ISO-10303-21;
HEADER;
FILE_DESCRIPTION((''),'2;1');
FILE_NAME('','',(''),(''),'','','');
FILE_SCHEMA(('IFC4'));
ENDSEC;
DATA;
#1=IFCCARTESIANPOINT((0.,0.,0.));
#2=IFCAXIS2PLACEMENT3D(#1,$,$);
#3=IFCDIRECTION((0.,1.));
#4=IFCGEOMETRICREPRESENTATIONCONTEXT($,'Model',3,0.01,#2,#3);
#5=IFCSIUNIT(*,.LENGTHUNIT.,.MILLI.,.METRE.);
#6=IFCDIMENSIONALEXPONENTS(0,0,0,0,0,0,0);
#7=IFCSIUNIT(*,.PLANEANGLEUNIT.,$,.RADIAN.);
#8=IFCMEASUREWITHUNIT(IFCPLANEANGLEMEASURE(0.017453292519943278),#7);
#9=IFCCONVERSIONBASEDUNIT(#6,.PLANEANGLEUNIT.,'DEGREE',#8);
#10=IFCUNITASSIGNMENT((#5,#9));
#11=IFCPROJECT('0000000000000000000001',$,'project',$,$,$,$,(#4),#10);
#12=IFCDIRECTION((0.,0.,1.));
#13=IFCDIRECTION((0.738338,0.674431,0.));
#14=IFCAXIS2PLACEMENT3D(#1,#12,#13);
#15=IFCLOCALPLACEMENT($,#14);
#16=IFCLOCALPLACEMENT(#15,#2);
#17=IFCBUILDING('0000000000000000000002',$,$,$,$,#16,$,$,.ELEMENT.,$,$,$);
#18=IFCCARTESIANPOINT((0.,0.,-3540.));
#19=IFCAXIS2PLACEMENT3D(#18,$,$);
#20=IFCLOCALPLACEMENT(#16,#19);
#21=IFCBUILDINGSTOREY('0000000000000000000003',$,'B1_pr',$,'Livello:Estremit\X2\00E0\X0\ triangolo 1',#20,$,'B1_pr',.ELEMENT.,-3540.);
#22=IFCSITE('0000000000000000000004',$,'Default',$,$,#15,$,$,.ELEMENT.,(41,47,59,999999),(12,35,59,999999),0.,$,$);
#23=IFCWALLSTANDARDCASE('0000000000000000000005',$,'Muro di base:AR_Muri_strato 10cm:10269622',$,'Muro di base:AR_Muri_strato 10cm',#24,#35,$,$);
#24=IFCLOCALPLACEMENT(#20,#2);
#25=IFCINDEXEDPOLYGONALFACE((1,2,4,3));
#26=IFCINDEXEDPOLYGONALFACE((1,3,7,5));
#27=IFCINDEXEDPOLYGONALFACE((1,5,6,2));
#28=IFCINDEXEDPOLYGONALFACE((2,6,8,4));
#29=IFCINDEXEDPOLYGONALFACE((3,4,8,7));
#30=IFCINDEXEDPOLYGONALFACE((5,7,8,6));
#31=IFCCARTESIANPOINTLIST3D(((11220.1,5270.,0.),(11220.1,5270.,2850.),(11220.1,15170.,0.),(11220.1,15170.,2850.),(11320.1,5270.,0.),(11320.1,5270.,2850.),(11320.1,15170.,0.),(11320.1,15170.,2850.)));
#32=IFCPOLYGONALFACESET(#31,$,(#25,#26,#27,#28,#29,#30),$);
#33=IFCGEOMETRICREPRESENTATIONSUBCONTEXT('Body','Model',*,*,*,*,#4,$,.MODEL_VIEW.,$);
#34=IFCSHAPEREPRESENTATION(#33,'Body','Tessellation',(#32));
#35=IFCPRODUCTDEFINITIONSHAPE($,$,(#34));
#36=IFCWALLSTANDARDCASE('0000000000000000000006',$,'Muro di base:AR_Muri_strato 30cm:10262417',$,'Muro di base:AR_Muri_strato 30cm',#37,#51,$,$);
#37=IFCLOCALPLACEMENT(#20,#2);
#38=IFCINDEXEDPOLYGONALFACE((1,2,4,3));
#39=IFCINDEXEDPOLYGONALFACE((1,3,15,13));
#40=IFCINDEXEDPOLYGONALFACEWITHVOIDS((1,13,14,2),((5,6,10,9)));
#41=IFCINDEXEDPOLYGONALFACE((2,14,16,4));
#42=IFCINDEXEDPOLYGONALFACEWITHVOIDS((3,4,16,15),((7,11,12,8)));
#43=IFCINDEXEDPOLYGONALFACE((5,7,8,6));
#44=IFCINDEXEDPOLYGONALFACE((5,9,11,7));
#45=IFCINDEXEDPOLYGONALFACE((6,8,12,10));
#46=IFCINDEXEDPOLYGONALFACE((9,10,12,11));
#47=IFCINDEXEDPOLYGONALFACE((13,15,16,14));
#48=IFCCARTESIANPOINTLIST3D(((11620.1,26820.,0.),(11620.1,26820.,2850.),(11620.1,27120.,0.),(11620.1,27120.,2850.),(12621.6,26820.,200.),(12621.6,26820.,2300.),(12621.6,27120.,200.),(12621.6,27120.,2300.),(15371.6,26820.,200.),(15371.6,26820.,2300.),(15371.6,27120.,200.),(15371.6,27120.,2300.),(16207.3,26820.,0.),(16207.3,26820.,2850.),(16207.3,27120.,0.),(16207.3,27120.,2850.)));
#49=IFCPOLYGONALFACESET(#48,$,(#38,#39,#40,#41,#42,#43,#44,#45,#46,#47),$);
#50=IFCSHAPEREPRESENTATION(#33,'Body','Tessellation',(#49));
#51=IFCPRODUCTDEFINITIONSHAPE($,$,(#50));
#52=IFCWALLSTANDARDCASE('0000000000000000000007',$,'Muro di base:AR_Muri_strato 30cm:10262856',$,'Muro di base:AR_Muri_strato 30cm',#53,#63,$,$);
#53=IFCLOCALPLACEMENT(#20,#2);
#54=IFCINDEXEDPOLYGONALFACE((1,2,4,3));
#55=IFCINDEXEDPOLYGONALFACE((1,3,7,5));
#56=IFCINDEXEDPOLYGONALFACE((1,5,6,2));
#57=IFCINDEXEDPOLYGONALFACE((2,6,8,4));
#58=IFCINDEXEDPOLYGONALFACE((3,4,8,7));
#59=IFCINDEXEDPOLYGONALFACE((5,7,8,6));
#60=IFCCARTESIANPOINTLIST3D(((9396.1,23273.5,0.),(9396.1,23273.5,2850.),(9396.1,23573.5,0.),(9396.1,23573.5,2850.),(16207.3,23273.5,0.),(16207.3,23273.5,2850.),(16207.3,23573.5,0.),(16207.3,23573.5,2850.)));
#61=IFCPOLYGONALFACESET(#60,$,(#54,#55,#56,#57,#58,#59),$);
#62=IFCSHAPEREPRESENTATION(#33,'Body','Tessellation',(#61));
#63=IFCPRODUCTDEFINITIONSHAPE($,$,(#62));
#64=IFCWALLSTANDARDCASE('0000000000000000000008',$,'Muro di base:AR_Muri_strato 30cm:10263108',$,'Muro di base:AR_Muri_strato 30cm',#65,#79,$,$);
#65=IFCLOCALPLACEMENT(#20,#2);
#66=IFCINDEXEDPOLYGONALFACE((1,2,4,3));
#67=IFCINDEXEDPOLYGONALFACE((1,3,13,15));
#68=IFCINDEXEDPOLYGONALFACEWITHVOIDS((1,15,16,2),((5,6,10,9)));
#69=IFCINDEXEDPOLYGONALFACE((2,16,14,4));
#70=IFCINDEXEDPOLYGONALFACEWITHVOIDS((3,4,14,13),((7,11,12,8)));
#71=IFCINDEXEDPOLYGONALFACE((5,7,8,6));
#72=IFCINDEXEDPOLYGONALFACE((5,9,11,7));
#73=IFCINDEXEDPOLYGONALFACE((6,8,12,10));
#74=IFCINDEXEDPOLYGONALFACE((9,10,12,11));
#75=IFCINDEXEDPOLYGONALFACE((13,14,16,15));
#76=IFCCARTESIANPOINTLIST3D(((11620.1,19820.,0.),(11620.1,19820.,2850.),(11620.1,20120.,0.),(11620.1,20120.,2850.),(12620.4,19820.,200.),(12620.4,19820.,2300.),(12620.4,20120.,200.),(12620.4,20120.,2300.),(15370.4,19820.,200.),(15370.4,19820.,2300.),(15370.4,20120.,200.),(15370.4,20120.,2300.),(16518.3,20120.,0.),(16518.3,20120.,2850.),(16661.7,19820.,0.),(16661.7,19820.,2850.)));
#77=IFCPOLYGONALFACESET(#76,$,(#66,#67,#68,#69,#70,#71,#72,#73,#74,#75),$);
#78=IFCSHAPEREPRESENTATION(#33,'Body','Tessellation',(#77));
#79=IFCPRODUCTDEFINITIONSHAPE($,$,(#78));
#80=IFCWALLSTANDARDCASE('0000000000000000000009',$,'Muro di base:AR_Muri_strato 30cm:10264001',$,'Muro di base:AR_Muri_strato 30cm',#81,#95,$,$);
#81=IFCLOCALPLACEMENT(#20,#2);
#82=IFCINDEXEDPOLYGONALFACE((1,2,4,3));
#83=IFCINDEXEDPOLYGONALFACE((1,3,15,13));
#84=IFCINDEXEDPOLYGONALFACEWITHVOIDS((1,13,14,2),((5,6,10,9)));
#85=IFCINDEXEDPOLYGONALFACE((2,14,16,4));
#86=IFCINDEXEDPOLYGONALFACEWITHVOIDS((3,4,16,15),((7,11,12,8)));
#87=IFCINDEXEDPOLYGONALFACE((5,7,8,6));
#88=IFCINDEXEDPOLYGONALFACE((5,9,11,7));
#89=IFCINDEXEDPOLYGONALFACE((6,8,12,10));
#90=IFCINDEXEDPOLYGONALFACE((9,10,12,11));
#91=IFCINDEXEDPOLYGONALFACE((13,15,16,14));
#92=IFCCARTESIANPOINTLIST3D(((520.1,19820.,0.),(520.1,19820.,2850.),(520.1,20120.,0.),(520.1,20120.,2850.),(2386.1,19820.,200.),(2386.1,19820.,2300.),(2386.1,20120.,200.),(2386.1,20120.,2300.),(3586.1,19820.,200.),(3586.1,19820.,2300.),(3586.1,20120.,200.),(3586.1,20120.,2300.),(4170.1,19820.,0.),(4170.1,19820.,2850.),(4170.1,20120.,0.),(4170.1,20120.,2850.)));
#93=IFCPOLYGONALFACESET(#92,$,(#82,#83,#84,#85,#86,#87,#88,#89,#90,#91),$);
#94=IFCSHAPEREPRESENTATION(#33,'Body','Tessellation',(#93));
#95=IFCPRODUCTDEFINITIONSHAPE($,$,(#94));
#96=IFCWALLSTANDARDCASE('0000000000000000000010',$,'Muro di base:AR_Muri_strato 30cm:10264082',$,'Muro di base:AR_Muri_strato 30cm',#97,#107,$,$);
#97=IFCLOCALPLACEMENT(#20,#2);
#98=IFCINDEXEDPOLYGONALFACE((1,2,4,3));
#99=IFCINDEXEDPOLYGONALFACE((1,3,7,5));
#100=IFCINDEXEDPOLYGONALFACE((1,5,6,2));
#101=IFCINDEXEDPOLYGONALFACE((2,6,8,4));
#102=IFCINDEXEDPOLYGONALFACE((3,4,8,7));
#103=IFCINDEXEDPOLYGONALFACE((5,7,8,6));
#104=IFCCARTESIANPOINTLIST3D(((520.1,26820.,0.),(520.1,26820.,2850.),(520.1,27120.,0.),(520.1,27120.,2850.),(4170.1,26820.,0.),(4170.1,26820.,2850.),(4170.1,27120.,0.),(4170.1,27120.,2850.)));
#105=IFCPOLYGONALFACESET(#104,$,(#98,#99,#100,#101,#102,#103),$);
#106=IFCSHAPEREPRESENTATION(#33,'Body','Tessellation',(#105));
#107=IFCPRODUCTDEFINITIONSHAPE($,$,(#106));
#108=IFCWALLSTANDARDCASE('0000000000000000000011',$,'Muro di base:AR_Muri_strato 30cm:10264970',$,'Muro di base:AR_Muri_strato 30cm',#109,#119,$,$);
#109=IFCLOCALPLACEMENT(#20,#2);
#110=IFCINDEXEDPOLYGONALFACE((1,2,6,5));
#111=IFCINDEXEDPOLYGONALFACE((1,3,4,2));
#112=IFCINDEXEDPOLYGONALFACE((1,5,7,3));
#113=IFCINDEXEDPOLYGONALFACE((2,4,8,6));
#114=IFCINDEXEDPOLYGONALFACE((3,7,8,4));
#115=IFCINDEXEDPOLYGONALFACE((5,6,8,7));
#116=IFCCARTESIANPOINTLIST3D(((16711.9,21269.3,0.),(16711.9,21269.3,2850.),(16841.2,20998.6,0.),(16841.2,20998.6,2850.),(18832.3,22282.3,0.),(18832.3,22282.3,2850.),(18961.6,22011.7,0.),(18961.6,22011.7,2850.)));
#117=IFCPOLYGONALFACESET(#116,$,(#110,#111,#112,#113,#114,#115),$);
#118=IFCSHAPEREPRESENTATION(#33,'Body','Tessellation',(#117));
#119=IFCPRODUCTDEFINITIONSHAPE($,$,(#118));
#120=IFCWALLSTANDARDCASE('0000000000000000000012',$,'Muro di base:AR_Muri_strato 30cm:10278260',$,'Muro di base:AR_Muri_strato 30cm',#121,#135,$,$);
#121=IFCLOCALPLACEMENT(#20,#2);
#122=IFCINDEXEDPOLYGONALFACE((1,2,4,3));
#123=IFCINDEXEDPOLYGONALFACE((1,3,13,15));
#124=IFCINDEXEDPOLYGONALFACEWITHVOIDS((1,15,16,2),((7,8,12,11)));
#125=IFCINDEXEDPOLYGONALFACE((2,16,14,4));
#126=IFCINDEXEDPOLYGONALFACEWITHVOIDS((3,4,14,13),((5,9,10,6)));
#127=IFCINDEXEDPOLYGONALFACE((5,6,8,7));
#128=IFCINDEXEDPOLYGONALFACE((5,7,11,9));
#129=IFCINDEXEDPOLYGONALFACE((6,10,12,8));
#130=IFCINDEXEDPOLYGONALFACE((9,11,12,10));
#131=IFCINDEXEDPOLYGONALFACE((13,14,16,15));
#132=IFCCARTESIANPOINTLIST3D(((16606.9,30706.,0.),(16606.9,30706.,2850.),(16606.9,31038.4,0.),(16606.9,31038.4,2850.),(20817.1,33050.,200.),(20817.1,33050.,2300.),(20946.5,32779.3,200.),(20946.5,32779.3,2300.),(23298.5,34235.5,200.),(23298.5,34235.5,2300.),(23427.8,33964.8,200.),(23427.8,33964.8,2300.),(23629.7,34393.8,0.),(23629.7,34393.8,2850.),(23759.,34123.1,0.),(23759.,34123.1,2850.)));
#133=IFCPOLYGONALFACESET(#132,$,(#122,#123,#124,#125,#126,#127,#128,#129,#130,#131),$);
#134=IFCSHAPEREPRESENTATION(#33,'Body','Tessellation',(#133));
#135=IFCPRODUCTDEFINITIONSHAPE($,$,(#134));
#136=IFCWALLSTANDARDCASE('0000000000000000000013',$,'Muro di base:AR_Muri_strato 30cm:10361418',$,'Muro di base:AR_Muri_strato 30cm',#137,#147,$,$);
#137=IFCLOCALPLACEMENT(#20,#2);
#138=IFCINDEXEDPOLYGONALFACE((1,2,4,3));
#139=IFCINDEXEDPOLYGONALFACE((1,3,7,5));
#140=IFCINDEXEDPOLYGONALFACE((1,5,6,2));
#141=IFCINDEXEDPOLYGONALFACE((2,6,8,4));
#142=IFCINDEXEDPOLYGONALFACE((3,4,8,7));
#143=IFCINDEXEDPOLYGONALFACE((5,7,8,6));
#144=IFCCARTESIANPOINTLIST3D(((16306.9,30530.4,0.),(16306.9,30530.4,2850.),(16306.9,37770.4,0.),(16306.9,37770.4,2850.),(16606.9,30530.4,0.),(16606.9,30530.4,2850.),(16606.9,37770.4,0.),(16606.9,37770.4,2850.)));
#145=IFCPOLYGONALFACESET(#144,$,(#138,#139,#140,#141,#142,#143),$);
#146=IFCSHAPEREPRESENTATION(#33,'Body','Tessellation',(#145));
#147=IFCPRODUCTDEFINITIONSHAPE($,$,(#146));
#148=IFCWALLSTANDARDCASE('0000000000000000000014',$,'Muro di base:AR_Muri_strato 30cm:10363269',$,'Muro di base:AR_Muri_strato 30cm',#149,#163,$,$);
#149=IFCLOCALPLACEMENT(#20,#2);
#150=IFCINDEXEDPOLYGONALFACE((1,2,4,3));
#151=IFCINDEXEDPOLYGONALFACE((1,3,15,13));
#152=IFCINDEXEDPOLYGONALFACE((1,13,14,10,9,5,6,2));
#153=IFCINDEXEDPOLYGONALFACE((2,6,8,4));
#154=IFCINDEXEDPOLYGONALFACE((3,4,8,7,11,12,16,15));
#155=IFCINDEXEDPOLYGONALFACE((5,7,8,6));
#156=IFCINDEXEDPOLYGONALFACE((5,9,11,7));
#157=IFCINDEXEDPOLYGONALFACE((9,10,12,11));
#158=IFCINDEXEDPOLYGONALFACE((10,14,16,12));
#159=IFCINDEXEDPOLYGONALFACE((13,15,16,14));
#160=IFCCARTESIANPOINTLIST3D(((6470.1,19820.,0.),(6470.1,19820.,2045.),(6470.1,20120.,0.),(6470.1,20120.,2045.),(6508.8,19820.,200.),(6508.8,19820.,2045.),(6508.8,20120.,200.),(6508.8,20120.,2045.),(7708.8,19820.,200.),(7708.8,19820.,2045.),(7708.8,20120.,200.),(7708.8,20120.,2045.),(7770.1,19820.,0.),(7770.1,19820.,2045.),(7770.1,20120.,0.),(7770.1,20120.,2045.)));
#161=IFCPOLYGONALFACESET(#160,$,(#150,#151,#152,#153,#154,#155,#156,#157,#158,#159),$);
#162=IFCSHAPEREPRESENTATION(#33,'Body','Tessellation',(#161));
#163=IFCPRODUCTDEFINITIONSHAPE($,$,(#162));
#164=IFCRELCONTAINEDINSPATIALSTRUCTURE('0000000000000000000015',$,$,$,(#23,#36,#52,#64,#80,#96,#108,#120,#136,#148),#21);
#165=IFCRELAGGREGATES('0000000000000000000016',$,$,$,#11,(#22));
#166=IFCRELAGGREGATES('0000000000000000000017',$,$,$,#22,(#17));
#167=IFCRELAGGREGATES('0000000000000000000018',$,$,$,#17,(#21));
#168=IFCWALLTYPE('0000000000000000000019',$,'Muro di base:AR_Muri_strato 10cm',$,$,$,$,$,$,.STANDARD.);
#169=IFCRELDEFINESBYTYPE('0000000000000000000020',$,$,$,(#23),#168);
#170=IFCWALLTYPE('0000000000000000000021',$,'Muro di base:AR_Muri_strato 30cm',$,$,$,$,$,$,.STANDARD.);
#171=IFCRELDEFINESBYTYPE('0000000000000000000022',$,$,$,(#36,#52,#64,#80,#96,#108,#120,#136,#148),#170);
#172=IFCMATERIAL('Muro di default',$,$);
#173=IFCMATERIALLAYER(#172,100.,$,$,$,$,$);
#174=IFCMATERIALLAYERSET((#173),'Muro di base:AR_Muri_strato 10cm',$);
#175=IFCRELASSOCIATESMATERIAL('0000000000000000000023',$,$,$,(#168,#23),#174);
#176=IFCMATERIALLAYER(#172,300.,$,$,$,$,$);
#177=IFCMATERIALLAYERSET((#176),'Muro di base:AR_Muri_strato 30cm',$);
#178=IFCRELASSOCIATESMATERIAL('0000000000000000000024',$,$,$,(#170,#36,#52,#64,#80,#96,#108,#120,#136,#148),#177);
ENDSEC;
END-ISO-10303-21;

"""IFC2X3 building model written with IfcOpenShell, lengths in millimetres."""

from ifc_helpers import new_model, entity, si_unit, converted_unit, direction, frame, frame_2d, origin, origin_2d_with_axis, place, context, subcontext, project, spatial, polyline, rectangle, outline, extrude, material, layer, layer_set, layer_usage, type_object, element, save


model = new_model("IFC2X3")

# Units and contexts
model_context = context("Model", 3, precision=0.01, world=origin(), true_north=direction((0.0, 1.0)))
body_context = subcontext(model_context, "Body", "Model", "MODEL_VIEW")
ifc_project = project(units=[si_unit("LENGTHUNIT", "METRE", prefix="MILLI"), converted_unit("PLANEANGLEUNIT", "DEGREE", entity("IfcPlaneAngleMeasure", 0.017453292519943278), si_unit("PLANEANGLEUNIT", "RADIAN"), dimensions=[0, 0, 0, 0, 0, 0, 0])], contexts=[model_context])

# Site, building, storey
site_placement = place(None, frame((0.0, 0.0, 0.0), z_axis=(0.0, 0.0, 1.0), x_axis=(0.738338, 0.674431, 0.0)))
site = spatial("IfcSite", under=ifc_project, at=site_placement, Name="Default", CompositionType="ELEMENT", RefLatitude=(41, 47, 59, 999999), RefLongitude=(12, 35, 59, 999999), RefElevation=0.0)
building_placement = place(site_placement, origin())
building = spatial("IfcBuilding", under=site, at=building_placement, CompositionType="ELEMENT")
storey_placement = place(building_placement, frame((0.0, 0.0, -3540.0)))
storey = spatial("IfcBuildingStorey", under=building, at=storey_placement, Name="B1_pr", ObjectType="Livello:Estremità triangolo 1", LongName="B1_pr", CompositionType="ELEMENT", Elevation=-3540.0)

# Wall
ifc_material = material(Name="Muro di default")
ifc_layer_1 = layer(ifc_material, 100.0)
ifc_layer_set_1 = layer_set([ifc_layer_1], Name="Muro di base:AR_Muri_strato 10cm")
ifc_layer_usage_1 = layer_usage(ifc_layer_set_1, "AXIS2", "NEGATIVE", 50.0)
wall_type_1 = type_object("IfcWallType", Name="Muro di base:AR_Muri_strato 10cm", PredefinedType="STANDARD", material=ifc_layer_set_1)
wall_1_placement = place(storey_placement, frame((11270.1, 15170.0, 0.0), z_axis=(0.0, 0.0, 1.0), x_axis=(0.0, -1.0, 0.0)))
element("IfcWallStandardCase", 1, at=wall_1_placement, inside=storey, type_object=wall_type_1, material=ifc_layer_usage_1, Name="Muro di base:AR_Muri_strato 10cm:10269622", ObjectType="Muro di base:AR_Muri_strato 10cm", context=body_context, shape_type="SweptSolid", body=[
    extrude(rectangle(XDim=9900.0, YDim=100.0, at=frame_2d((4950.0, 0.0), x_axis=(-1.0, 0.0))), origin(), (0.0, 0.0, 1.0), 2850.0),
])

# Wall, opening
ifc_layer_2 = layer(ifc_material, 300.0)
ifc_layer_set_2 = layer_set([ifc_layer_2], Name="Muro di base:AR_Muri_strato 30cm")
ifc_layer_usage_2 = layer_usage(ifc_layer_set_2, "AXIS2", "NEGATIVE", 150.0)
wall_type_2 = type_object("IfcWallType", Name="Muro di base:AR_Muri_strato 30cm", PredefinedType="STANDARD", material=ifc_layer_set_2)
wall_2_placement = place(storey_placement, frame((11620.1, 26970.0, 0.0)))
wall_2 = element("IfcWallStandardCase", 2, at=wall_2_placement, inside=storey, type_object=wall_type_2, material=ifc_layer_usage_2, Name="Muro di base:AR_Muri_strato 30cm:10262417", ObjectType="Muro di base:AR_Muri_strato 30cm", context=body_context, shape_type="SweptSolid", body=[
    extrude(rectangle(XDim=4587.2, YDim=300.0, at=frame_2d((2293.6, 0.0), x_axis=(-1.0, 0.0))), origin(), (0.0, 0.0, 1.0), 2850.0),
])
opening_1_placement = place(wall_2_placement, frame((-11620.1, -26970.0, 200.0)))
element("IfcOpeningElement", 3, at=opening_1_placement, cuts=wall_2, ObjectType="Opening", context=body_context, shape_type="SweptSolid", body=[
    extrude(rectangle(XDim=2100.0, YDim=2750.0, at=origin_2d_with_axis()), frame((13996.6, 25596.0, 1050.0), z_axis=(0.0, 1.0, 0.0), x_axis=(0.0, 0.0, -1.0)), (0.0, 0.0, 1.0), 3048.0),
])

# Wall
ifc_layer_usage_3 = layer_usage(ifc_layer_set_2, "AXIS2", "NEGATIVE", 150.0)
wall_3_placement = place(storey_placement, frame((9396.1, 23423.5, 0.0)))
element("IfcWallStandardCase", 4, at=wall_3_placement, inside=storey, type_object=wall_type_2, material=ifc_layer_usage_3, Name="Muro di base:AR_Muri_strato 30cm:10262856", ObjectType="Muro di base:AR_Muri_strato 30cm", context=body_context, shape_type="SweptSolid", body=[
    extrude(rectangle(XDim=6811.2, YDim=300.0, at=frame_2d((3405.6, 0.0), x_axis=(-1.0, 0.0))), origin(), (0.0, 0.0, 1.0), 2850.0),
])

# Walls, openings
ifc_layer_usage_4 = layer_usage(ifc_layer_set_2, "AXIS2", "NEGATIVE", 150.0)
wall_4_placement = place(storey_placement, frame((11620.1, 19970.0, 0.0)))
wall_4 = element("IfcWallStandardCase", 5, at=wall_4_placement, inside=storey, type_object=wall_type_2, material=ifc_layer_usage_4, Name="Muro di base:AR_Muri_strato 30cm:10263108", ObjectType="Muro di base:AR_Muri_strato 30cm", context=body_context, shape_type="SweptSolid", body=[
    extrude(outline(polyline([(5041.6, -150.0), (4898.3, 150.0), (0.0, 150.0), (0.0, -150.0), (5041.6, -150.0)])), origin(), (0.0, 0.0, 1.0), 2850.0),
])
opening_2_placement = place(wall_4_placement, frame((-11620.1, -19970.0, 200.0)))
element("IfcOpeningElement", 6, at=opening_2_placement, cuts=wall_4, ObjectType="Opening", context=body_context, shape_type="SweptSolid", body=[
    extrude(rectangle(XDim=2100.0, YDim=2750.0, at=frame_2d((0.0, 0.0), x_axis=(0.0, 1.0))), frame((13995.4, 18296.0, 1050.0), z_axis=(0.0, 1.0, 0.0), x_axis=(1.0, 0.0, 0.0)), (0.0, 0.0, 1.0), 3048.0),
])
ifc_layer_usage_5 = layer_usage(ifc_layer_set_2, "AXIS2", "NEGATIVE", 150.0)
wall_5_placement = place(storey_placement, frame((520.1, 19970.0, 0.0)))
wall_5 = element("IfcWallStandardCase", 7, at=wall_5_placement, inside=storey, type_object=wall_type_2, material=ifc_layer_usage_5, Name="Muro di base:AR_Muri_strato 30cm:10264001", ObjectType="Muro di base:AR_Muri_strato 30cm", context=body_context, shape_type="SweptSolid", body=[
    extrude(rectangle(XDim=3650.0, YDim=300.0, at=frame_2d((1825.0, 0.0), x_axis=(-1.0, 0.0))), origin(), (0.0, 0.0, 1.0), 2850.0),
])
opening_3_placement = place(wall_5_placement, frame((-520.1, -19970.0, 200.0)))
element("IfcOpeningElement", 8, at=opening_3_placement, cuts=wall_5, ObjectType="Opening", context=body_context, shape_type="SweptSolid", body=[
    extrude(rectangle(XDim=2100.0, YDim=1200.0, at=frame_2d((0.0, 0.0), x_axis=(1.0, 0.0))), frame((2986.1, 18596.0, 1050.0), z_axis=(0.0, 1.0, 0.0), x_axis=(0.0, 0.0, -1.0)), (0.0, 0.0, 1.0), 3048.0),
])

# Walls
ifc_layer_usage_6 = layer_usage(ifc_layer_set_2, "AXIS2", "NEGATIVE", 150.0)
wall_6_placement = place(storey_placement, frame((520.1, 26970.0, 0.0)))
element("IfcWallStandardCase", 9, at=wall_6_placement, inside=storey, type_object=wall_type_2, material=ifc_layer_usage_6, Name="Muro di base:AR_Muri_strato 30cm:10264082", ObjectType="Muro di base:AR_Muri_strato 30cm", context=body_context, shape_type="SweptSolid", body=[
    extrude(rectangle(XDim=3650.0, YDim=300.0, at=frame_2d((1825.0, 0.0), x_axis=(-1.0, 0.0))), origin(), (0.0, 0.0, 1.0), 2850.0),
])
ifc_layer_usage_7 = layer_usage(ifc_layer_set_2, "AXIS2", "NEGATIVE", 150.0)
wall_7_placement = place(storey_placement, frame((16776.5, 21133.9, 0.0), z_axis=(0.0, 0.0, 1.0), x_axis=(0.902302, 0.431105, 0.0)))
element("IfcWallStandardCase", 10, at=wall_7_placement, inside=storey, type_object=wall_type_2, material=ifc_layer_usage_7, Name="Muro di base:AR_Muri_strato 30cm:10264970", ObjectType="Muro di base:AR_Muri_strato 30cm", context=body_context, shape_type="SweptSolid", body=[
    extrude(rectangle(XDim=2350.0, YDim=300.0, at=frame_2d((1175.0, 0.0), x_axis=(-1.0, 0.0))), origin(), (0.0, 0.0, 1.0), 2850.0),
])

# Wall, opening
ifc_layer_usage_8 = layer_usage(ifc_layer_set_2, "AXIS2", "NEGATIVE", 150.0)
wall_8_placement = place(storey_placement, frame((23694.4, 34258.4, 0.0), z_axis=(0.0, 0.0, 1.0), x_axis=(-0.902305, -0.431097, 0.0)))
wall_8 = element("IfcWallStandardCase", 11, at=wall_8_placement, inside=storey, type_object=wall_type_2, material=ifc_layer_usage_8, Name="Muro di base:AR_Muri_strato 30cm:10278260", ObjectType="Muro di base:AR_Muri_strato 30cm", context=body_context, shape_type="SweptSolid", body=[
    extrude(outline(polyline([(7783.2, -150.0), (7926.5, 150.0), (0.0, 150.0), (0.0, -150.0), (7783.2, -150.0)])), origin(), (0.0, 0.0, 1.0), 2850.0),
])
opening_4_placement = place(wall_8_placement, frame((36148.3, 20697.0, 200.0), z_axis=(0.0, 0.0, 1.0), x_axis=(-0.902305, 0.431097, 0.0)))
element("IfcOpeningElement", 12, at=opening_4_placement, cuts=wall_8, ObjectType="Opening", context=body_context, shape_type="SweptSolid", body=[
    extrude(rectangle(XDim=2100.0, YDim=2750.0, at=frame_2d((0.0, 0.0), x_axis=(0.0, 1.0))), frame((21400.8, 35017.9, 1050.0), z_axis=(0.431097, -0.902305, 0.0), x_axis=(-0.902305, -0.431097, 0.0)), (0.0, 0.0, 1.0), 3048.0),
])

# Wall
ifc_layer_usage_9 = layer_usage(ifc_layer_set_2, "AXIS2", "NEGATIVE", 150.0)
wall_9_placement = place(storey_placement, frame((16456.9, 30530.4, 0.0), z_axis=(0.0, 0.0, 1.0), x_axis=(0.0, 1.0, 0.0)))
element("IfcWallStandardCase", 13, at=wall_9_placement, inside=storey, type_object=wall_type_2, material=ifc_layer_usage_9, Name="Muro di base:AR_Muri_strato 30cm:10361418", ObjectType="Muro di base:AR_Muri_strato 30cm", context=body_context, shape_type="SweptSolid", body=[
    extrude(rectangle(XDim=7240.0, YDim=300.0, at=frame_2d((3620.0, 0.0), x_axis=(-1.0, 0.0))), origin(), (0.0, 0.0, 1.0), 2850.0),
])

# Wall, opening
ifc_layer_usage_10 = layer_usage(ifc_layer_set_2, "AXIS2", "NEGATIVE", 150.0)
wall_10_placement = place(storey_placement, frame((6470.1, 19970.0, 0.0)))
wall_10 = element("IfcWallStandardCase", 14, at=wall_10_placement, inside=storey, type_object=wall_type_2, material=ifc_layer_usage_10, Name="Muro di base:AR_Muri_strato 30cm:10363269", ObjectType="Muro di base:AR_Muri_strato 30cm", context=body_context, shape_type="SweptSolid", body=[
    extrude(rectangle(XDim=1300.0, YDim=300.0, at=frame_2d((650.0, 0.0), x_axis=(-1.0, 0.0))), origin(), (0.0, 0.0, 1.0), 2045.0),
])
opening_5_placement = place(wall_10_placement, frame((-6470.1, -19970.0, 200.0)))
element("IfcOpeningElement", 15, at=opening_5_placement, cuts=wall_10, ObjectType="Opening", context=body_context, shape_type="SweptSolid", body=[
    extrude(rectangle(XDim=2100.0, YDim=1200.0, at=origin_2d_with_axis()), frame((7108.8, 18596.0, 1050.0), z_axis=(0.0, 1.0, 0.0), x_axis=(0.0, 0.0, -1.0)), (0.0, 0.0, 1.0), 3048.0),
])

save(model, "model.ifc")
